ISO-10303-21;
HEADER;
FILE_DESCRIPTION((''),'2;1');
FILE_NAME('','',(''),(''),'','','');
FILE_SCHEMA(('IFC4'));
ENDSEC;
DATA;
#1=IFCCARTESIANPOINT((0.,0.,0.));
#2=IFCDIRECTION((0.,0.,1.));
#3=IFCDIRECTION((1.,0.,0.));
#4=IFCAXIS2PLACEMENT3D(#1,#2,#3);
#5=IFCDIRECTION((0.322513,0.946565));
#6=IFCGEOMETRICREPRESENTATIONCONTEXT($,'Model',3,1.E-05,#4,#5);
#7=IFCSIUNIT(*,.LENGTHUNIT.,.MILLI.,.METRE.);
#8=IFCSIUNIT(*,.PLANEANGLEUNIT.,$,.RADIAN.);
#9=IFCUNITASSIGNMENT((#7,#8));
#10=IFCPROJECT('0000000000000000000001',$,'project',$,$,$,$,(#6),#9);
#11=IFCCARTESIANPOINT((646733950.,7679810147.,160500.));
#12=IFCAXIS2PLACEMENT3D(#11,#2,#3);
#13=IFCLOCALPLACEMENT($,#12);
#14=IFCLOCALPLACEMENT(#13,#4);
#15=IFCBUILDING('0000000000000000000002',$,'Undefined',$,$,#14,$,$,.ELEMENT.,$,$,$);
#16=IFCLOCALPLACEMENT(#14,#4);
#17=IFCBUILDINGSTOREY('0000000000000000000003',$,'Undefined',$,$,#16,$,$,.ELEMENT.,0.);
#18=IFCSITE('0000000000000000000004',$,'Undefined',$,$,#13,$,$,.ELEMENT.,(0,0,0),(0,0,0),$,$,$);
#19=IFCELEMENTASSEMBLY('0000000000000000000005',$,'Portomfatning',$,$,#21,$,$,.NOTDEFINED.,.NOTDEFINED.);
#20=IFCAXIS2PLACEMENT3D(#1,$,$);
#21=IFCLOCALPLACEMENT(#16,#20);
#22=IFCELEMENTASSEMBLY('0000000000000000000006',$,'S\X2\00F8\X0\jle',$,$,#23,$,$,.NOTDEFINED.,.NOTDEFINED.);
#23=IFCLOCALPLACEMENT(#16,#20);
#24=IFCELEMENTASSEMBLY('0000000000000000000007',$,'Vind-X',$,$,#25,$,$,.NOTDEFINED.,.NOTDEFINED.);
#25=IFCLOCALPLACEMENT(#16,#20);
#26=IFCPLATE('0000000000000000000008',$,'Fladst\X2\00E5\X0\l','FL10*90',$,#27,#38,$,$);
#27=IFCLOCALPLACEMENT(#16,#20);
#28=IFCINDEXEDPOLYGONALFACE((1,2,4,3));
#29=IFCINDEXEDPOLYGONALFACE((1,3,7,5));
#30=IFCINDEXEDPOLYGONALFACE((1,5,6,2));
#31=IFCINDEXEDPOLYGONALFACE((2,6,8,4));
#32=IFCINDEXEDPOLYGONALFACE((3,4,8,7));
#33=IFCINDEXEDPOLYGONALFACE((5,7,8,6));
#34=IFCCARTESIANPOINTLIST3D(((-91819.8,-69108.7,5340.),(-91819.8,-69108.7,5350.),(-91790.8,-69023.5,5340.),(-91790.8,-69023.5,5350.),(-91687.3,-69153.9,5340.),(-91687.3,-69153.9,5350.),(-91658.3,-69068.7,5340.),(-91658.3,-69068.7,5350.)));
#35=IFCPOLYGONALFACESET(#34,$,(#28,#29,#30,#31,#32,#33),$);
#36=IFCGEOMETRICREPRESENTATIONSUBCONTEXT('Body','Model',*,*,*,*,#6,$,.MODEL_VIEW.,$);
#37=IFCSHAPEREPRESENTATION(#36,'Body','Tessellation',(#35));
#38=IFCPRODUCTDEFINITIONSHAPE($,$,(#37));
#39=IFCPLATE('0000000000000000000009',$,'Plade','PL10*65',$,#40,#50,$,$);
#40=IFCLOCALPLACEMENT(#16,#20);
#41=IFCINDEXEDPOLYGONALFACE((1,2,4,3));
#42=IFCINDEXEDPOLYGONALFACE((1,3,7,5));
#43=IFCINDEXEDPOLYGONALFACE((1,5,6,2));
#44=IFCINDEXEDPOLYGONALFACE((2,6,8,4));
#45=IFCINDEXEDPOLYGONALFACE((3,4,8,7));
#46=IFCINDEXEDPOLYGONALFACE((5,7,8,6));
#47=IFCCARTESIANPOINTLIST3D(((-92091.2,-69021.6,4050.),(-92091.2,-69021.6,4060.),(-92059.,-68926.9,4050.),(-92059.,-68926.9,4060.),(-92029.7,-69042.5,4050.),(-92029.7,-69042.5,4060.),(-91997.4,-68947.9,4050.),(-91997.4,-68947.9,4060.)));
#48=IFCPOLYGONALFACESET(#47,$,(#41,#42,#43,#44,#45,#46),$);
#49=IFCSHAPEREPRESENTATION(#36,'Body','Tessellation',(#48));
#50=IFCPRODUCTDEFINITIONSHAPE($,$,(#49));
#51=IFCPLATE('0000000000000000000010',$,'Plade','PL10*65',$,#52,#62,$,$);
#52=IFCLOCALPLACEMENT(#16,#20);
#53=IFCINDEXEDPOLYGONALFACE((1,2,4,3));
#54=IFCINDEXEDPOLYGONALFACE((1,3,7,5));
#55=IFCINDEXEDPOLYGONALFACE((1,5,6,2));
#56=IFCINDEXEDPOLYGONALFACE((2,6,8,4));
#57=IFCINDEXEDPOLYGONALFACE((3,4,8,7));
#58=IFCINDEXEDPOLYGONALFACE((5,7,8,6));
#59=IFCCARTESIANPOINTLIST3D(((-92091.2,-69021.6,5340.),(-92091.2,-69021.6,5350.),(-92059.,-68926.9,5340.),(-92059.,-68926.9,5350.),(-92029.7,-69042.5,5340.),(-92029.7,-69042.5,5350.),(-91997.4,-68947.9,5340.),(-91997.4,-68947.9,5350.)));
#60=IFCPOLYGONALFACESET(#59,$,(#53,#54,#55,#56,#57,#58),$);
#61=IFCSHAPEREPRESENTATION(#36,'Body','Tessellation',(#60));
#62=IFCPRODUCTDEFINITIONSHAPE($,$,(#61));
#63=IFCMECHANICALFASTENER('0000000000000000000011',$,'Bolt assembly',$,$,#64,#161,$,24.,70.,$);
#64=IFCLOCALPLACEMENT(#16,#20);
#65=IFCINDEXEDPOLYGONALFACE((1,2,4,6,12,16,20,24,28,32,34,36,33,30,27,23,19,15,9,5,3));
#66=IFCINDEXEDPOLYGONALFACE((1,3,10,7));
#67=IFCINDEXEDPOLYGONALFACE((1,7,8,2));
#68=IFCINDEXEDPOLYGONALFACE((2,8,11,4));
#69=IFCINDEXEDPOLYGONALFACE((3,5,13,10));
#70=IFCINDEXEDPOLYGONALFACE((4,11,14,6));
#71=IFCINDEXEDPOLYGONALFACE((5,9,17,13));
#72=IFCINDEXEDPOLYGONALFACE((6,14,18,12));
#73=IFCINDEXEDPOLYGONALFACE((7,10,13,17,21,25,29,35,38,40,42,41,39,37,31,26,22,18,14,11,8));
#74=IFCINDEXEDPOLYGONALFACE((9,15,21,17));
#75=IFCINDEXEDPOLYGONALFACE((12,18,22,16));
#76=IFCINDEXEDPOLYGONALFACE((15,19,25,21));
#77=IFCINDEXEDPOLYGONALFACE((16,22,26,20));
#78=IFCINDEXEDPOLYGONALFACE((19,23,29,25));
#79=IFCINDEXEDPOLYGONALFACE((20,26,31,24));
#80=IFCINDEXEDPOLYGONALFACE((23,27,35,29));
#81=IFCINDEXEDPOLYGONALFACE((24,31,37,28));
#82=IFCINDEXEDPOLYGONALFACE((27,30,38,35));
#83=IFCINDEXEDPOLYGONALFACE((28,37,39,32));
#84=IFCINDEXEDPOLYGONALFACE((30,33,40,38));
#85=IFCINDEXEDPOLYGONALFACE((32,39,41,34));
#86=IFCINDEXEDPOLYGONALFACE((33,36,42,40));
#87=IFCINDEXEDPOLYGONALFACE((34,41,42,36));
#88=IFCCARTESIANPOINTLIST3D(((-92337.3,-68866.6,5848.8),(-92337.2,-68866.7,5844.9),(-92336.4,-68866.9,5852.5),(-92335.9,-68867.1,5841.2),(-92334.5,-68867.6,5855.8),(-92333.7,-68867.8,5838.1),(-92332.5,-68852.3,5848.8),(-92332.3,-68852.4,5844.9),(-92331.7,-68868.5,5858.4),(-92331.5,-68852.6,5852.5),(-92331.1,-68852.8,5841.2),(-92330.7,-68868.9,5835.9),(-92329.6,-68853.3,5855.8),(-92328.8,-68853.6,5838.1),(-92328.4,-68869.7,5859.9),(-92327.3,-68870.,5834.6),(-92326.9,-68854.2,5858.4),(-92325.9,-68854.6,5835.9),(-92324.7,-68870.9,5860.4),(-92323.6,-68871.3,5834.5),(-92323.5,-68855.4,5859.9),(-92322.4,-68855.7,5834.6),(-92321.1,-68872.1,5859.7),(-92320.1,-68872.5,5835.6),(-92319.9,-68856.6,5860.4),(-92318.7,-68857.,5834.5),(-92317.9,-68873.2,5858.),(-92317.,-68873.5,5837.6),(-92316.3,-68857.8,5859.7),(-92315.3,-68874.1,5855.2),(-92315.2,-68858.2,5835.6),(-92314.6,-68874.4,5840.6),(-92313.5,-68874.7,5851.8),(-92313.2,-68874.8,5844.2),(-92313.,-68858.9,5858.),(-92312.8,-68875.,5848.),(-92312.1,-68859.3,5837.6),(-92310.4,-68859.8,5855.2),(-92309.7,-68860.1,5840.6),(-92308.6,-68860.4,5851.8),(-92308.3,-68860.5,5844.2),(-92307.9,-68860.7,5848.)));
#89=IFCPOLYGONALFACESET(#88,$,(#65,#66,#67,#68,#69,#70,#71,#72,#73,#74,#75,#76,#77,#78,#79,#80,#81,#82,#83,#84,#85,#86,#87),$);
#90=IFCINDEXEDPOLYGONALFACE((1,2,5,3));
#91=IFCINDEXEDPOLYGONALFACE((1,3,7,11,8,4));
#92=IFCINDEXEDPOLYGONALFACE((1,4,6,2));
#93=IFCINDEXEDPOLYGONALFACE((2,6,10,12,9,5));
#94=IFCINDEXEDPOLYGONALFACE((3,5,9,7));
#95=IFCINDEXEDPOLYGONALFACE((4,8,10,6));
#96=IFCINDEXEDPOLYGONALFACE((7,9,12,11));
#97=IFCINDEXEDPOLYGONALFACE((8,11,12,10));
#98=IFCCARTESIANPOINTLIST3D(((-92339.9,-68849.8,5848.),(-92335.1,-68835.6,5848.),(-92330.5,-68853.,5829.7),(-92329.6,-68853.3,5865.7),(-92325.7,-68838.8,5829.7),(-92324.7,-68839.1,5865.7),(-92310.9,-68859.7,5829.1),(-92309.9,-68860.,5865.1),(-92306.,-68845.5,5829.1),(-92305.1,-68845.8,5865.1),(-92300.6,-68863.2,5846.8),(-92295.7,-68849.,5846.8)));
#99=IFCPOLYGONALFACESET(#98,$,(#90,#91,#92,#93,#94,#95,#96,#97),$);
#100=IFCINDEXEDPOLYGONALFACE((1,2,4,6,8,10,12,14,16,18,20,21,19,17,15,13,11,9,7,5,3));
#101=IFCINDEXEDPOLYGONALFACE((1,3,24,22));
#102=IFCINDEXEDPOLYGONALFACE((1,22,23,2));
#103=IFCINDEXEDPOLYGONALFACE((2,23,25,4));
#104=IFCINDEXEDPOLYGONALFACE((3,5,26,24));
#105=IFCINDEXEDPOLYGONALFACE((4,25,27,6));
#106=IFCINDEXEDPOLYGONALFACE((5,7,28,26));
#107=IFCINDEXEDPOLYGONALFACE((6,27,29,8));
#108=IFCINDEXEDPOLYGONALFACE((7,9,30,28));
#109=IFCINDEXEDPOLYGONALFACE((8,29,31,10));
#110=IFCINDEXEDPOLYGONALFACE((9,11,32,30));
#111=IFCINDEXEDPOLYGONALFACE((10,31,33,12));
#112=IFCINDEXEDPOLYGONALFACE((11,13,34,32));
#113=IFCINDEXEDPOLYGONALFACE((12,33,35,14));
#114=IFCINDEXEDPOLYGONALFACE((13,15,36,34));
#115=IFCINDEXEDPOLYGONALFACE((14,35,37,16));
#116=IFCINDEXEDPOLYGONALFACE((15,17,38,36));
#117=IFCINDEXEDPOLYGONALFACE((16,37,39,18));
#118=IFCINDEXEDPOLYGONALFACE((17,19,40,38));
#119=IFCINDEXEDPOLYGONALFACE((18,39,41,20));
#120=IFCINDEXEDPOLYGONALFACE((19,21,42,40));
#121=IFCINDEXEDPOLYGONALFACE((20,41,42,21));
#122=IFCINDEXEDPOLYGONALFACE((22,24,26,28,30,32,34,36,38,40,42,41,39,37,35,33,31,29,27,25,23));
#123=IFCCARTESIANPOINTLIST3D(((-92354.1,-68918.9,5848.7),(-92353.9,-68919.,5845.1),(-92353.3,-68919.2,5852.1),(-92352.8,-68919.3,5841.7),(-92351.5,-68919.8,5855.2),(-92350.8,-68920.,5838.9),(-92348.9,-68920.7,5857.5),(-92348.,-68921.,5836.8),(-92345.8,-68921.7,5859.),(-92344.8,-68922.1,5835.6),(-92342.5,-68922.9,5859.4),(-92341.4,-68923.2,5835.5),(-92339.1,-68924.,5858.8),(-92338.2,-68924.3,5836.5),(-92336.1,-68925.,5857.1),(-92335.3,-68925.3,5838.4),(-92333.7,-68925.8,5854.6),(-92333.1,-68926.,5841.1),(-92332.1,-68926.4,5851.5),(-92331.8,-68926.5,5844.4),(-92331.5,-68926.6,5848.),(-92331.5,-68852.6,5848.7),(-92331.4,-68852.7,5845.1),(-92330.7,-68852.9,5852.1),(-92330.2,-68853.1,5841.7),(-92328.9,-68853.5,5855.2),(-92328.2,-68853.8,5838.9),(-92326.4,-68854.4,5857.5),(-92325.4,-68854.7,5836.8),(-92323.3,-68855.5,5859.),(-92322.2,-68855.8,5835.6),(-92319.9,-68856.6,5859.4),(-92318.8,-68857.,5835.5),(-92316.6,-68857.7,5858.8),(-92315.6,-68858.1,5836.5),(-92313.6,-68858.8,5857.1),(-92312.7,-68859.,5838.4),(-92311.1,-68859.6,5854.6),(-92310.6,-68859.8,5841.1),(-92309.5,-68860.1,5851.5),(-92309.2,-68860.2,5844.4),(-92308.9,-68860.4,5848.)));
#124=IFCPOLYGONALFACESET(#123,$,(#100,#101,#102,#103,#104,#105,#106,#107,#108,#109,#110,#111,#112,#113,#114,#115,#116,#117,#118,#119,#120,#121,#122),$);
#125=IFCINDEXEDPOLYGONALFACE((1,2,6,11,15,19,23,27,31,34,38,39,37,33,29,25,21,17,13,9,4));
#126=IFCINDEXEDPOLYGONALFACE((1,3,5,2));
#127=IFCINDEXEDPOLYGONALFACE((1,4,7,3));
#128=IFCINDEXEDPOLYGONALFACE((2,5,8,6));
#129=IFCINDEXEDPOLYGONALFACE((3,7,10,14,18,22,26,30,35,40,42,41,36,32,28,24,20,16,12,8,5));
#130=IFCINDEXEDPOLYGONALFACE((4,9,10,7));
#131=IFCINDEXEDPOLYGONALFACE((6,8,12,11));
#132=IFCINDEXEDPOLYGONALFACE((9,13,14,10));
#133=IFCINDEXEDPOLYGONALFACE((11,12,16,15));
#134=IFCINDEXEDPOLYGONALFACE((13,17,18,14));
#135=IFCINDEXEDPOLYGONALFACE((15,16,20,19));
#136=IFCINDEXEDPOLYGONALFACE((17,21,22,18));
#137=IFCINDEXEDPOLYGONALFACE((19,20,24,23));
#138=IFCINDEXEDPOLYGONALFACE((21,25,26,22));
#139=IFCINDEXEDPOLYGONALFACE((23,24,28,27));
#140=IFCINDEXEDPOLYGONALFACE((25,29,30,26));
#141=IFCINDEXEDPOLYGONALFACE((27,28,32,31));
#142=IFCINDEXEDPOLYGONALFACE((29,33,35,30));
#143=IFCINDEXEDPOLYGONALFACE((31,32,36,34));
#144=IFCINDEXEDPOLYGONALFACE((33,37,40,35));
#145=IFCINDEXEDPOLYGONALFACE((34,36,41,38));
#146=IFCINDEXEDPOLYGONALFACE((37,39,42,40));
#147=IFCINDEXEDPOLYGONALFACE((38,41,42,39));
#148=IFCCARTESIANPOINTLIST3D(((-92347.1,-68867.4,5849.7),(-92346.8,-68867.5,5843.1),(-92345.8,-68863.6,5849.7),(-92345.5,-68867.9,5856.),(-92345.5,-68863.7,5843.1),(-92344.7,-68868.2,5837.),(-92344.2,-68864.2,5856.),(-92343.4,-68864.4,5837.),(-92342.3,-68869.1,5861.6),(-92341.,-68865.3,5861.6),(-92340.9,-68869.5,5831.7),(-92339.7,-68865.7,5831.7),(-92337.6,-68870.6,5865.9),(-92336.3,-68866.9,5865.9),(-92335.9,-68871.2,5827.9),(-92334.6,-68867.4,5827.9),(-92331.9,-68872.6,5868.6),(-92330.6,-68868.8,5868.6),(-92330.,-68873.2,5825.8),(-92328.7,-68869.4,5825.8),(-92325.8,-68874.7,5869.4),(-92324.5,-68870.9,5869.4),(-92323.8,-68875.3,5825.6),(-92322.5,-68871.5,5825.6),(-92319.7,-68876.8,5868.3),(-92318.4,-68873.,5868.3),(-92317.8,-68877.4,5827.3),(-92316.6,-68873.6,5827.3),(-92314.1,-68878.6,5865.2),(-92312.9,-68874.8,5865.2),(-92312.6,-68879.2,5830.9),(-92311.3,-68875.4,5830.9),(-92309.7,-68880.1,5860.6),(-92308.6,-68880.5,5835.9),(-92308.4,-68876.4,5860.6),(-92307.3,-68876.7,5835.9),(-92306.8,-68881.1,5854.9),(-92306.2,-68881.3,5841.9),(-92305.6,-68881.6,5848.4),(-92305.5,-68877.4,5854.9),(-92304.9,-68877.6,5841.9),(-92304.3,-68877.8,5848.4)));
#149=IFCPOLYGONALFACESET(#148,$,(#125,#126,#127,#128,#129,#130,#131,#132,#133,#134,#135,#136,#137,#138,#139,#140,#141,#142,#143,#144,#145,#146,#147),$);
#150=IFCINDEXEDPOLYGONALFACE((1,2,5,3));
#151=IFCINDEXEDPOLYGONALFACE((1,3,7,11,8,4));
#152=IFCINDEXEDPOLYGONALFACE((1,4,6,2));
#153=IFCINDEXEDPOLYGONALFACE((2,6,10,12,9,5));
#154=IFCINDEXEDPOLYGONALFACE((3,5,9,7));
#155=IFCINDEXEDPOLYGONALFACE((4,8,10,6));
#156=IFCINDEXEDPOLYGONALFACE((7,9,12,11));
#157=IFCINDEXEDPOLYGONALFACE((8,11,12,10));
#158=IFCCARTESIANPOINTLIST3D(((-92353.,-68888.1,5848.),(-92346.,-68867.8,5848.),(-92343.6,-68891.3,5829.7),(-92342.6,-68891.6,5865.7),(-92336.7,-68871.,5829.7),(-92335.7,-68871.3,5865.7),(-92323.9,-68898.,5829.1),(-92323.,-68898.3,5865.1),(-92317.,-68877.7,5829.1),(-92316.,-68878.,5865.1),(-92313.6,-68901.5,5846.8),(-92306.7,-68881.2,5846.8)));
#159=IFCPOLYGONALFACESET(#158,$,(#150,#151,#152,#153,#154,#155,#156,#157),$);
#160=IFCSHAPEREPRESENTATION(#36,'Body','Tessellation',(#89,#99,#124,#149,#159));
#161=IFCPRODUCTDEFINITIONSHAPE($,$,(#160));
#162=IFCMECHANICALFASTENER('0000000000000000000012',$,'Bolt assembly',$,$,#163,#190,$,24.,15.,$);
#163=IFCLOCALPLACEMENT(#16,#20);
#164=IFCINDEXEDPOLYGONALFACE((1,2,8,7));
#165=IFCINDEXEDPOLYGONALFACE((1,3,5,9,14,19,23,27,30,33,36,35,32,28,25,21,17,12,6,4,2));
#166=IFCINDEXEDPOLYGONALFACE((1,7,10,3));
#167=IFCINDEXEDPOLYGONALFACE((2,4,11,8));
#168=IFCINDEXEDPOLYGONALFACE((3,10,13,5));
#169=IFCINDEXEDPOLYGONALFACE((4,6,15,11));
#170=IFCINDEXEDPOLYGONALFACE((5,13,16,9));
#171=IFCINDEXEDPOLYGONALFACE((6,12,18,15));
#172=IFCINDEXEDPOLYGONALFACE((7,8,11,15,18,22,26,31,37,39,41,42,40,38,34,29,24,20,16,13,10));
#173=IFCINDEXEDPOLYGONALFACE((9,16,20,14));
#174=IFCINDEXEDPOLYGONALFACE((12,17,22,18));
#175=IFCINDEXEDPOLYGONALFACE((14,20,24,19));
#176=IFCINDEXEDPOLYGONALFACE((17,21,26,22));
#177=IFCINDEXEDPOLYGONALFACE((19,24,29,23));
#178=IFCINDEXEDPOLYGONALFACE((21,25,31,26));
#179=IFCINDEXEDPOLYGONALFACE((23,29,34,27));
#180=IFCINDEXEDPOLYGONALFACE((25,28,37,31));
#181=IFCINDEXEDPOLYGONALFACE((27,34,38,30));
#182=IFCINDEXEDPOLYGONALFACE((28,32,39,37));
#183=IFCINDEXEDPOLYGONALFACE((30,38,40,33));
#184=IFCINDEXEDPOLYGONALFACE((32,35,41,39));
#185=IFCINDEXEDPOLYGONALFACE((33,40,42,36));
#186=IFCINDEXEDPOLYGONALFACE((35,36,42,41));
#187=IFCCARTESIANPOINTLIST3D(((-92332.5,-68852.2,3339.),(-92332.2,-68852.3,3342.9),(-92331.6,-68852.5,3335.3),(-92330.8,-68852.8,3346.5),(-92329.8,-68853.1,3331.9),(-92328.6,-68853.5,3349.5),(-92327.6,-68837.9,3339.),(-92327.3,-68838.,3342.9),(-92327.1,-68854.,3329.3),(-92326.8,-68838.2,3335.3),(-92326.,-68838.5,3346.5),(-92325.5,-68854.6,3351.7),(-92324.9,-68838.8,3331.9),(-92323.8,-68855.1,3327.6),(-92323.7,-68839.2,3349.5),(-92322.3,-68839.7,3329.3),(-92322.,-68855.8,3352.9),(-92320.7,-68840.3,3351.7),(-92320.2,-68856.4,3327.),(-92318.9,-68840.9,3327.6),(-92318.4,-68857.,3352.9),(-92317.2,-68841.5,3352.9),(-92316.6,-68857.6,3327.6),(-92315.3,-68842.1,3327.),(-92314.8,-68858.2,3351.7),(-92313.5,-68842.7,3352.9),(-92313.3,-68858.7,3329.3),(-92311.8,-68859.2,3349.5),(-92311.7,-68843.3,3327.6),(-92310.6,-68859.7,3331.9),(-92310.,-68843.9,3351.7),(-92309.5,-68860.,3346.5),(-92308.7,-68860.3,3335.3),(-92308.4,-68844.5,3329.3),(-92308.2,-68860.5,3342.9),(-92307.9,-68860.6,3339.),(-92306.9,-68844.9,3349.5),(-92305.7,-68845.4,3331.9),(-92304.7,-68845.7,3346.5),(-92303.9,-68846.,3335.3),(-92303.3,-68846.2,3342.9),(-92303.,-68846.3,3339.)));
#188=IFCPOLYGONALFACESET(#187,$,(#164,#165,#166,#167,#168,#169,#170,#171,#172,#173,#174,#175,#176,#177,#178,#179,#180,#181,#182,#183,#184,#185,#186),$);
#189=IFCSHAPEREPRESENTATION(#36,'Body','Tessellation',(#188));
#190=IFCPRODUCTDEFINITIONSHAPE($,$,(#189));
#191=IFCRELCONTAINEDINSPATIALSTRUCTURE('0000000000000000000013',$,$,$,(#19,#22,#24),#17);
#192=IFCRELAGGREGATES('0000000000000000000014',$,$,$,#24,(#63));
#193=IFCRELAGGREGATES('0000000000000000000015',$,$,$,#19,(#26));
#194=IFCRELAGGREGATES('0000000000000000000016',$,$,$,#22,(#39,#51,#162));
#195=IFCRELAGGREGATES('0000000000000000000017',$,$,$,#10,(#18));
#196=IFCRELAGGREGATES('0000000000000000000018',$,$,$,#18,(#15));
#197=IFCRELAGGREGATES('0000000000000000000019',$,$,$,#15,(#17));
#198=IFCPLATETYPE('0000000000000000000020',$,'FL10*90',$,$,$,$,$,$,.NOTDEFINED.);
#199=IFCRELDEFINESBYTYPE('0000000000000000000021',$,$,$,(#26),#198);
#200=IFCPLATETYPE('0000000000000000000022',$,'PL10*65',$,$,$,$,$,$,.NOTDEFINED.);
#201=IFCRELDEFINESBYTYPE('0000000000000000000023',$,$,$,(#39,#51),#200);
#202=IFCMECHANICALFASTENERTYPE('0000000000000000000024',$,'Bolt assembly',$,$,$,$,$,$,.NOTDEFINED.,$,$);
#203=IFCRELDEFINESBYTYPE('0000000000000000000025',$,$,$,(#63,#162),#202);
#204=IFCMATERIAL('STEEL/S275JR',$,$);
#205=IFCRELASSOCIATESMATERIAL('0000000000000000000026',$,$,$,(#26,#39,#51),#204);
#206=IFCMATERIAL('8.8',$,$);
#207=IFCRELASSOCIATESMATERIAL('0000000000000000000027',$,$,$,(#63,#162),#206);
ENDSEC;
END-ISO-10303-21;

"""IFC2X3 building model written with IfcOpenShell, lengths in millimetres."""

from ifc_helpers import new_model, si_unit, direction, frame, origin_with_axes, origin_2d_with_axis, place, context, subcontext, project, spatial, polyline, circle, outline, extrude, source, transform, mapped, material, type_object, element, aggregate, save


model = new_model("IFC2X3")

# Units and contexts
model_context = context("Model", 3, precision=1e-05, world=origin_with_axes(), true_north=direction((0.322513, 0.946565)))
body_context = subcontext(model_context, "Body", "Model", "MODEL_VIEW")
ifc_project = project(units=[si_unit("LENGTHUNIT", "METRE", prefix="MILLI"), si_unit("PLANEANGLEUNIT", "RADIAN")], contexts=[model_context])

# Site, building, storey
site_placement = place(None, frame((646733950.0, 7679810147.0, 160500.0), z_axis=(0.0, 0.0, 1.0), x_axis=(1.0, 0.0, 0.0)))
site = spatial("IfcSite", under=ifc_project, at=site_placement, Name="Undefined", CompositionType="ELEMENT", RefLatitude=(0, 0, 0), RefLongitude=(0, 0, 0))
building_placement = place(site_placement, origin_with_axes())
building = spatial("IfcBuilding", under=site, at=building_placement, Name="Undefined", CompositionType="ELEMENT")
storey_placement = place(building_placement, origin_with_axes())
storey = spatial("IfcBuildingStorey", under=building, at=storey_placement, Name="Undefined", CompositionType="ELEMENT", Elevation=0.0)

# Element assemblies
assembly_1_placement = place(storey_placement, origin_with_axes())
assembly_1 = element("IfcElementAssembly", 1, at=assembly_1_placement, inside=storey, Name="Portomfatning", AssemblyPlace="NOTDEFINED", PredefinedType="NOTDEFINED")
assembly_2_placement = place(storey_placement, origin_with_axes())
assembly_2 = element("IfcElementAssembly", 2, at=assembly_2_placement, inside=storey, Name="Søjle", AssemblyPlace="NOTDEFINED", PredefinedType="NOTDEFINED")

# Shared definitions
ifc_material_1 = material(Name="STEEL/S275JR")

# Element assembly
assembly_3_placement = place(storey_placement, origin_with_axes())
assembly_3 = element("IfcElementAssembly", 3, at=assembly_3_placement, inside=storey, Name="Vind-X", AssemblyPlace="NOTDEFINED", PredefinedType="NOTDEFINED")

# Plates
plate_type_1 = type_object("IfcPlateType", Name="FL10*90", PredefinedType="NOTDEFINED")
plate_1_placement = place(assembly_1_placement, frame((-91672.8, -69111.3, 5345.0), z_axis=(0.0, 0.0, -1.0), x_axis=(-0.946565, 0.322513, 0.0)))
plate_1 = element("IfcPlate", 4, at=plate_1_placement, type_object=plate_type_1, material=ifc_material_1, Name="Fladstål", Description="FL10*90", context=body_context, shape_type="SweptSolid", body=[
    extrude(outline(polyline([(0.0, -45.0), (0.0, 45.0), (140.0, 45.0), (140.0, -45.0), (0.0, -45.0)])), frame((0.0, 0.0, -5.0), z_axis=(0.0, 0.0, 1.0), x_axis=(1.0, 0.0, 0.0)), (0.0, 0.0, 1.0), 10.0),
])
plate_type_2 = type_object("IfcPlateType", Name="PL10*65", PredefinedType="NOTDEFINED")
plate_2_placement = place(assembly_2_placement, frame((-92091.2, -69021.6, 4055.0), z_axis=(0.0, 0.0, 1.0), x_axis=(0.946565, -0.322513, 0.0)))
plate_2 = element("IfcPlate", 5, at=plate_2_placement, type_object=plate_type_2, material=ifc_material_1, Name="Plade", Description="PL10*65", context=body_context, shape_type="SweptSolid", body=[
    extrude(outline(polyline([(0.0, 0.0), (65.0, 0.0), (65.0, 100.0), (0.0, 100.0), (0.0, 0.0)])), frame((0.0, 0.0, -5.0), z_axis=(0.0, 0.0, 1.0), x_axis=(1.0, 0.0, 0.0)), (0.0, 0.0, 1.0), 10.0),
])
plate_3_placement = place(assembly_2_placement, frame((-92091.2, -69021.6, 5345.0), z_axis=(0.0, 0.0, 1.0), x_axis=(0.946565, -0.322513, 0.0)))
plate_3 = element("IfcPlate", 6, at=plate_3_placement, type_object=plate_type_2, material=ifc_material_1, Name="Plade", Description="PL10*65", context=body_context, shape_type="SweptSolid", body=[
    extrude(outline(polyline([(0.0, 0.0), (65.0, 0.0), (65.0, 100.0), (0.0, 100.0), (0.0, 0.0)])), frame((0.0, 0.0, -5.0), z_axis=(0.0, 0.0, 1.0), x_axis=(1.0, 0.0, 0.0)), (0.0, 0.0, 1.0), 10.0),
])

# Mechanical fasteners
ifc_material_2 = material(Name="8.8")
mechanical_fastener_type = type_object("IfcMechanicalFastenerType", Name="Bolt assembly")
shared_shape_1 = source(origin_with_axes(), body_context, "Body", "SweptSolid", [
    extrude(circle(Radius=13.0, at=origin_2d_with_axis()), frame((0.0, 0.0, 0.0), z_axis=(0.0, 1.0, 0.0), x_axis=(1.0, 0.0, 0.0)), (0.0, 0.0, 1.0), 15.1),
    extrude(outline(polyline([(18.0, -10.4), (18.0, 10.4), (0.0, 20.8), (-18.0, 10.4), (-18.0, -10.4), (0.0, -20.8), (18.0, -10.4)])), frame((0.0, -15.0, 0.0), z_axis=(0.0, 1.0, 0.0), x_axis=(1.0, 0.0, 0.0)), (0.0, 0.0, 1.0), 15.0),
    extrude(circle(Radius=12.0, at=origin_2d_with_axis()), frame((0.0, 0.0, 0.0), z_axis=(0.0, 1.0, 0.0), x_axis=(1.0, 0.0, 0.0)), (0.0, 0.0, 1.0), 70.0),
    extrude(circle(Radius=22.0, at=origin_2d_with_axis()), frame((0.0, 15.0, 0.0), z_axis=(0.0, 1.0, 0.0), x_axis=(1.0, 0.0, 0.0)), (0.0, 0.0, 1.0), 4.0),
    extrude(outline(polyline([(18.0, -10.4), (18.0, 10.4), (0.0, 20.8), (-18.0, 10.4), (-18.0, -10.4), (0.0, -20.8), (18.0, -10.4)])), frame((0.0, 19.0, 0.0), z_axis=(0.0, 1.0, 0.0), x_axis=(1.0, 0.0, 0.0)), (0.0, 0.0, 1.0), 21.5),
])
mechanical_fastener_1_placement = place(assembly_3_placement, frame((-92320.2, -68856.5, 5847.4), z_axis=(-0.450012, 0.153328, 0.879761), x_axis=(-0.832751, 0.283734, -0.475416)))
mechanical_fastener_1 = element("IfcMechanicalFastener", 7, at=mechanical_fastener_1_placement, type_object=mechanical_fastener_type, material=ifc_material_2, Name="Bolt assembly", NominalDiameter=24.0, NominalLength=70.0, context=body_context, shape_type="MappedRepresentation", body=[
    mapped(shared_shape_1, transform((0.0, 0.0, 0.0))),
])
aggregate(assembly_3, [mechanical_fastener_1])
aggregate(assembly_1, [plate_1])
shared_shape_2 = source(origin_with_axes(), body_context, "Body", "SweptSolid", [
    extrude(circle(Radius=13.0, at=origin_2d_with_axis()), frame((0.0, -7.5, 0.0), z_axis=(0.0, 1.0, 0.0), x_axis=(1.0, 0.0, 0.0)), (0.0, 0.0, 1.0), 15.1),
])
mechanical_fastener_2_placement = place(assembly_2_placement, frame((-92317.8, -68849.3, 3340.0), z_axis=(0.946565, -0.322513, 0.0), x_axis=(0.0, 0.0, -1.0)))
mechanical_fastener_2 = element("IfcMechanicalFastener", 8, at=mechanical_fastener_2_placement, type_object=mechanical_fastener_type, material=ifc_material_2, Name="Bolt assembly", NominalDiameter=24.0, NominalLength=15.0, context=body_context, shape_type="MappedRepresentation", body=[
    mapped(shared_shape_2, transform((0.0, 0.0, 0.0))),
])
aggregate(assembly_2, [plate_2, plate_3, mechanical_fastener_2])

save(model, "model.ifc")
